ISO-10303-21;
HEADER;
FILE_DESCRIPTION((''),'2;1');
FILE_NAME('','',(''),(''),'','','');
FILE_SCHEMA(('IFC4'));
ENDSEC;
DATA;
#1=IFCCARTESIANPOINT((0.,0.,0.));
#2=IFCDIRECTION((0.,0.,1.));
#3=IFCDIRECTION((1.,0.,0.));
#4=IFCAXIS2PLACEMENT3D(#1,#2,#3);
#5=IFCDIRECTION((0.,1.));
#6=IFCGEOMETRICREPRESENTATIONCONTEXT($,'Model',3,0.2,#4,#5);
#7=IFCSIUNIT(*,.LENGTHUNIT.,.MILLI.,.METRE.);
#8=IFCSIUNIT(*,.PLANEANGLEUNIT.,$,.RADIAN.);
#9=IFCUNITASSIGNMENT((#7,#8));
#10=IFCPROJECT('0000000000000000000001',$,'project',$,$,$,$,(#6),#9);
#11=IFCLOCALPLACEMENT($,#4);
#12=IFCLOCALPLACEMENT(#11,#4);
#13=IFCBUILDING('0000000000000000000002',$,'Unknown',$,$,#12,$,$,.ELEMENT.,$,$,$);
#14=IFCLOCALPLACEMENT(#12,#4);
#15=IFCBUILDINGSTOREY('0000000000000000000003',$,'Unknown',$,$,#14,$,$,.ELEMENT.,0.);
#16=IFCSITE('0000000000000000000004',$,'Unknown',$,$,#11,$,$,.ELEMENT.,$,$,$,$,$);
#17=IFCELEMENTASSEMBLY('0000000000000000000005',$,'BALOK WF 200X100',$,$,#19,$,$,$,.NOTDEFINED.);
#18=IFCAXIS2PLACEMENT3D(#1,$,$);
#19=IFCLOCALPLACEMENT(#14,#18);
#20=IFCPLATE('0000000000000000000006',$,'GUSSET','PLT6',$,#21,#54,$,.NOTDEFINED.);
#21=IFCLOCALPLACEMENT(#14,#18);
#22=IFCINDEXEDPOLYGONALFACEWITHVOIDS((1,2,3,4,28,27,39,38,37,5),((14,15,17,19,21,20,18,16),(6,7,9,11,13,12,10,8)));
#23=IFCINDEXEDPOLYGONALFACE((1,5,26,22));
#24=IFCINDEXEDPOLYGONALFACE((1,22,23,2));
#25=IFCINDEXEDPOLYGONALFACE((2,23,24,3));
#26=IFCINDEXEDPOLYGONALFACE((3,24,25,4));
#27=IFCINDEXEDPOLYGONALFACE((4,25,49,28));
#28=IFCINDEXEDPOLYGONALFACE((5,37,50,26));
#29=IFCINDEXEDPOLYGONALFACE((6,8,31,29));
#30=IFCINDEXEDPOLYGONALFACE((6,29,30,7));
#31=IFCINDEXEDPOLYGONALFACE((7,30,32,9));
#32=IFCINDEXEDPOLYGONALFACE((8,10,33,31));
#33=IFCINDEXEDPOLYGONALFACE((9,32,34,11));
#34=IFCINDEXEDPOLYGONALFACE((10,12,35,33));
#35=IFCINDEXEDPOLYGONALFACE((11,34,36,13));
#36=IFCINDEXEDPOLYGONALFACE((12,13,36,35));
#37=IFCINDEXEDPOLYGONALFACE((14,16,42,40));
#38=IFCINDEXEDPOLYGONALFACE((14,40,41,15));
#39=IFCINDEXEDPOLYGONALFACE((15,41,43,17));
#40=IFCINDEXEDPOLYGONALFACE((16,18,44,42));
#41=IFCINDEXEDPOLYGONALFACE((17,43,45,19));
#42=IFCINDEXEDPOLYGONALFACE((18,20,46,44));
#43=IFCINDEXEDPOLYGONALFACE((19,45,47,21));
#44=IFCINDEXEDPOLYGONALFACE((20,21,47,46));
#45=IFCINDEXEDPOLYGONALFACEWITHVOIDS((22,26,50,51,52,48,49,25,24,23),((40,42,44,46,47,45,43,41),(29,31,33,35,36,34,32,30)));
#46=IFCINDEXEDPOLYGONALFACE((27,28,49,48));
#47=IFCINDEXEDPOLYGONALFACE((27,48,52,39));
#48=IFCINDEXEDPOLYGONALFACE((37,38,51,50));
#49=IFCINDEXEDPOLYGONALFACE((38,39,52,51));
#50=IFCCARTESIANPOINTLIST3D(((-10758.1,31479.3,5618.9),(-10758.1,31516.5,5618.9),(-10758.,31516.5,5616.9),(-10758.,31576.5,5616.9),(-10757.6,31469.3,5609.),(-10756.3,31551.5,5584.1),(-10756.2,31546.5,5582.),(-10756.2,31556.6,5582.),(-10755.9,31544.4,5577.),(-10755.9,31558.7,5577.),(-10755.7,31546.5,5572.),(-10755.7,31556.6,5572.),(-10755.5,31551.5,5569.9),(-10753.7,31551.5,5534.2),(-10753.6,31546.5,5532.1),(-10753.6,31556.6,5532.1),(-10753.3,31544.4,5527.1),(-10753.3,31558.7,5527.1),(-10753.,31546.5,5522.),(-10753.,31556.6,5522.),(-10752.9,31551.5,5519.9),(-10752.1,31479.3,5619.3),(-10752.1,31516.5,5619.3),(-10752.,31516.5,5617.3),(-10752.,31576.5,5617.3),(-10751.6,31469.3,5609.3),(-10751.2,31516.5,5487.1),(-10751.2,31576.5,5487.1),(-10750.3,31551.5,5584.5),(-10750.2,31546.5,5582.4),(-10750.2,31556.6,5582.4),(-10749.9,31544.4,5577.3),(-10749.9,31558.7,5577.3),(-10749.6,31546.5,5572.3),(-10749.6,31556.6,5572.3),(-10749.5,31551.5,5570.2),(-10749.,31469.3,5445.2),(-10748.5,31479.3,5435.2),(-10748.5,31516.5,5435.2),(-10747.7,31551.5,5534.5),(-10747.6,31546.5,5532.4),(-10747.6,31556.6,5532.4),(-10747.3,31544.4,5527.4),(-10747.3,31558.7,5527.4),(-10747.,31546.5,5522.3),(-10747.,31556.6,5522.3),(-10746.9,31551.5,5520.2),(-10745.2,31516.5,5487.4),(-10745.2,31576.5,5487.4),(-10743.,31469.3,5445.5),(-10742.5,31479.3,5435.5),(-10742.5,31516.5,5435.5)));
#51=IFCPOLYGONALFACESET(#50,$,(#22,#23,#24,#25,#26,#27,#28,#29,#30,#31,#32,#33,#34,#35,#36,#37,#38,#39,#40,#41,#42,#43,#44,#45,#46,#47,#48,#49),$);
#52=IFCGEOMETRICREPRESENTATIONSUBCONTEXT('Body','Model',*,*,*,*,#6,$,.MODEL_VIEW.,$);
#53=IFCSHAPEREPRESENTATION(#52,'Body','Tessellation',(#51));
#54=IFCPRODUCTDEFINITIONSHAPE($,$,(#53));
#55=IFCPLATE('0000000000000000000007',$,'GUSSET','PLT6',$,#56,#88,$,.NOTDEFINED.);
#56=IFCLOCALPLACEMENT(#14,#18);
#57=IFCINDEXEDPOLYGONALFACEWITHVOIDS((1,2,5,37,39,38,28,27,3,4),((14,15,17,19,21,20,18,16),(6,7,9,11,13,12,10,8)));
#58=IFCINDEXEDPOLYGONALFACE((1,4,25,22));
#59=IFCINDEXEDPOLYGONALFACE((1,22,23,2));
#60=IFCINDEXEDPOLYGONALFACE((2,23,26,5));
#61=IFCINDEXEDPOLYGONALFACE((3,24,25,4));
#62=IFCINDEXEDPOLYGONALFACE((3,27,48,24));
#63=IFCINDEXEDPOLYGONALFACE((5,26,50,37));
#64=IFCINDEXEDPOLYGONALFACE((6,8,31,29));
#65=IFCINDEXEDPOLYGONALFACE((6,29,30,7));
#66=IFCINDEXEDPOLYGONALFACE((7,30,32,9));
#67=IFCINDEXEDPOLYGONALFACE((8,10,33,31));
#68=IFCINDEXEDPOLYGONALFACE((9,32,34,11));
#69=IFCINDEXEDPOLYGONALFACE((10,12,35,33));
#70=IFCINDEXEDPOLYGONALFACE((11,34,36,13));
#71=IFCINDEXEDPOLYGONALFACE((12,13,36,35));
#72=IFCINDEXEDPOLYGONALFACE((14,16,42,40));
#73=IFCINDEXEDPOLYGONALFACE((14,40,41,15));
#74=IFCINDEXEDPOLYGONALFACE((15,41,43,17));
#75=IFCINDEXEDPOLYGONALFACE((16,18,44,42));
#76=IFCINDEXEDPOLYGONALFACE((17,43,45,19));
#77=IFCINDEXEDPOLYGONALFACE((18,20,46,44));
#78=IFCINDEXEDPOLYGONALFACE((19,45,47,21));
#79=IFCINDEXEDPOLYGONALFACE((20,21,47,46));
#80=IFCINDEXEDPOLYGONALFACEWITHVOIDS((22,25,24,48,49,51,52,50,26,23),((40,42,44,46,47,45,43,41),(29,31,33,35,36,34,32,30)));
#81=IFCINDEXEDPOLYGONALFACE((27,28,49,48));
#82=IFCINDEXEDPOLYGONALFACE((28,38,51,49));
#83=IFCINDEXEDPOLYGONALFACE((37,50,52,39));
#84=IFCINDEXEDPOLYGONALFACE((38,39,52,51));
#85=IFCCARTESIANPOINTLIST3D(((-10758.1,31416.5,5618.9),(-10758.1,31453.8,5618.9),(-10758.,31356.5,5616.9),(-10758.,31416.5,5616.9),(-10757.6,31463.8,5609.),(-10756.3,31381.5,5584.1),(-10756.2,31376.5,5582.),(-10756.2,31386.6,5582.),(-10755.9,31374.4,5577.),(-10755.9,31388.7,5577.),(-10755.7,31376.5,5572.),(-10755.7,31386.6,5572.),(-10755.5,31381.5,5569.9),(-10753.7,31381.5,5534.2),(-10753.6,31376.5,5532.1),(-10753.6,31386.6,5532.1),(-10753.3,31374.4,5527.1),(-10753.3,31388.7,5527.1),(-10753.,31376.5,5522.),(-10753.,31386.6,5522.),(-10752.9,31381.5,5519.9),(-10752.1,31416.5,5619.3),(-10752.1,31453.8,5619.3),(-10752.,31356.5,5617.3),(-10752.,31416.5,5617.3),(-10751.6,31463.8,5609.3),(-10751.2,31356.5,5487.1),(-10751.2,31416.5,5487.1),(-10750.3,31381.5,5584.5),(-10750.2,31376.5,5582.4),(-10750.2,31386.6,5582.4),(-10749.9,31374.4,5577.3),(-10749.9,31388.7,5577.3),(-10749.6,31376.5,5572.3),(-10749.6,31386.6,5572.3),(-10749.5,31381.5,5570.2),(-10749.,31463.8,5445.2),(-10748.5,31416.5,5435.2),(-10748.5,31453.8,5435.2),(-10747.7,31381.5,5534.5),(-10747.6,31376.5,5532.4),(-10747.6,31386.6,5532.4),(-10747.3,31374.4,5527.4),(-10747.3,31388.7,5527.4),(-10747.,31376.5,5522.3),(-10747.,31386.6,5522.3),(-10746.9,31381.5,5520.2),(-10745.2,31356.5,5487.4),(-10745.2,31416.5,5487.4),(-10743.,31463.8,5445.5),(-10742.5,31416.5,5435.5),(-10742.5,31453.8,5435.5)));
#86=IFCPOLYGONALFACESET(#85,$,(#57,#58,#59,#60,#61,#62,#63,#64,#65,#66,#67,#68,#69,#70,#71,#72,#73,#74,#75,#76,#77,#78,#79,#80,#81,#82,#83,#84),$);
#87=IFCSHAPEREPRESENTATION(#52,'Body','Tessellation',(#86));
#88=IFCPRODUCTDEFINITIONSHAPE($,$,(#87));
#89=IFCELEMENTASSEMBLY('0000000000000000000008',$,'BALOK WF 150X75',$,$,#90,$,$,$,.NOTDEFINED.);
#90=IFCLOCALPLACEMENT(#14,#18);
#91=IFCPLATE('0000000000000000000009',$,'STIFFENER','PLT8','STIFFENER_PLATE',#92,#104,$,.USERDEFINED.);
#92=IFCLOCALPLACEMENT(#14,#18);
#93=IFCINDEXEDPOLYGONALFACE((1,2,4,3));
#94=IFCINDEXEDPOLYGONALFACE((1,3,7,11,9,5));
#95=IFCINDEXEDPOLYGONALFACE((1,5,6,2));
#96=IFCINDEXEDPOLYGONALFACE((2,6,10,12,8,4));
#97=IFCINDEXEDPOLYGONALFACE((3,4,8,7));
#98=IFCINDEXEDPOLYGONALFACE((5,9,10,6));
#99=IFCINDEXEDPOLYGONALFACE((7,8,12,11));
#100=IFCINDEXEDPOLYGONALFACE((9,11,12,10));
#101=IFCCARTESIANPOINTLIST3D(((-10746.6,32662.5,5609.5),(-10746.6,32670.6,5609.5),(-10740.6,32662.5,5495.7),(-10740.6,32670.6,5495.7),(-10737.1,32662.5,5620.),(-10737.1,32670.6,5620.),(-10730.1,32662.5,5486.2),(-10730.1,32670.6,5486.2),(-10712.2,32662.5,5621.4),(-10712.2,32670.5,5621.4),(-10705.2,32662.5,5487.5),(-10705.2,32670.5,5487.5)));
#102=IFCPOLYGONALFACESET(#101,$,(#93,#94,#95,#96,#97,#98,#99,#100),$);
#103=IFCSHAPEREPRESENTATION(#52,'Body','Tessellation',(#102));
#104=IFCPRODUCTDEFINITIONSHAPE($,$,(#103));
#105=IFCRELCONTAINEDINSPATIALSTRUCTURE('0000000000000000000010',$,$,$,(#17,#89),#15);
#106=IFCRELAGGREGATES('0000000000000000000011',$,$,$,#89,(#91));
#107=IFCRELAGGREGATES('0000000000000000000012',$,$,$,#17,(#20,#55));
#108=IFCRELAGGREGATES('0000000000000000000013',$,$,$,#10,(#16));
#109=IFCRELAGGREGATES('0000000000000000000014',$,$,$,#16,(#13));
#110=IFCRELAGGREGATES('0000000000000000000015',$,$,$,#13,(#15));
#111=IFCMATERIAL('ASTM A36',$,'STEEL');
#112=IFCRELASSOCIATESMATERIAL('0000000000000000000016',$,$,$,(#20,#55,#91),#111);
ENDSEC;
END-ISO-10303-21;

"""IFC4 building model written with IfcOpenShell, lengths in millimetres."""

from ifc_helpers import new_model, si_unit, direction, frame, origin_with_axes, place, context, subcontext, project, spatial, line, indexed_curve, outline, extrude, material, element, aggregate, save


model = new_model("IFC4")

# Units and contexts
model_context = context("Model", 3, precision=0.2, world=origin_with_axes(), true_north=direction((0.0, 1.0)))
body_context = subcontext(model_context, "Body", "Model", "MODEL_VIEW")
ifc_project = project(units=[si_unit("LENGTHUNIT", "METRE", prefix="MILLI"), si_unit("PLANEANGLEUNIT", "RADIAN")], contexts=[model_context])

# Site, building, storey
site_placement = place(None, origin_with_axes())
site = spatial("IfcSite", under=ifc_project, at=site_placement, Name="Unknown", CompositionType="ELEMENT")
building_placement = place(site_placement, origin_with_axes())
building = spatial("IfcBuilding", under=site, at=building_placement, Name="Unknown", CompositionType="ELEMENT")
storey_placement = place(building_placement, origin_with_axes())
storey = spatial("IfcBuildingStorey", under=building, at=storey_placement, Name="Unknown", CompositionType="ELEMENT", Elevation=0.0)

# Element assemblies, plates, voiding features
assembly_1_placement = place(storey_placement, frame((-7044.1, 31466.5, 5721.5), z_axis=(0.0, 1.0, 0.0), x_axis=(-0.99863, 0.0, -0.052336)))
assembly_1 = element("IfcElementAssembly", 1, at=assembly_1_placement, inside=storey, Name="BALOK WF 200X100", PredefinedType="NOTDEFINED")
ifc_material_1 = material(Name="ASTM A36", Category="STEEL")
plate_1_placement = place(assembly_1_placement, frame((3711.2, 92.0, 2.8), z_axis=(1.0, 0.0, 0.0), x_axis=(0.0, 0.0, 1.0)))
plate_1 = element("IfcPlate", 2, at=plate_1_placement, material=ifc_material_1, Name="GUSSET", Description="PLT6", PredefinedType="NOTDEFINED", context=body_context, shape_type="SolidModel", body=[
    extrude(outline(indexed_curve([(0.0, 0.0), (47.2, 0.0), (47.2, 2.0), (107.3, 2.0), (107.3, 132.0), (47.2, 132.0), (47.2, 184.0), (0.0, 184.0)], segments=[line(1, 2, 3, 4, 5, 6, 7, 8, 1)])), frame((0.0, 0.0, 3.0), z_axis=(0.0, 0.0, 1.0), x_axis=(1.0, 0.0, 0.0)), (0.0, 0.0, -1.0), 6.0),
])
voiding_feature_1_placement = place(plate_1_placement, frame((10.0, 0.0, 0.0), z_axis=(0.0, 0.0, 1.0), x_axis=(-0.707107, 0.707107, 0.0)))
element("IfcVoidingFeature", 3, at=voiding_feature_1_placement, cuts=plate_1, Name="SLAB", PredefinedType="HOLE", context=body_context, shape_type="SolidModel", body=[
    extrude(outline(indexed_curve([(0.0, 0.0), (14.1, 0.0), (7.1, 7.1)], segments=[line(1, 2, 3, 1)])), frame((0.0, 0.0, 3.0), z_axis=(0.0, 0.0, 1.0), x_axis=(1.0, 0.0, 0.0)), (0.0, 0.0, -1.0), 6.0),
])
voiding_feature_2_placement = place(plate_1_placement, frame((0.0, 174.0, 0.0), z_axis=(0.0, 0.0, 1.0), x_axis=(0.707107, 0.707107, 0.0)))
element("IfcVoidingFeature", 4, at=voiding_feature_2_placement, cuts=plate_1, Name="SLAB", PredefinedType="HOLE", context=body_context, shape_type="SolidModel", body=[
    extrude(outline(indexed_curve([(0.0, 0.0), (14.1, 0.0), (7.1, 7.1)], segments=[line(1, 2, 3, 1)])), frame((0.0, 0.0, 3.0), z_axis=(0.0, 0.0, 1.0), x_axis=(1.0, 0.0, 0.0)), (0.0, 0.0, -1.0), 6.0),
])
voiding_feature_3_placement = place(plate_1_placement, frame((82.3, 92.0, -3.5), z_axis=(-1.0, 0.0, 0.0), x_axis=(0.0, 0.0, 1.0)))
element("IfcVoidingFeature", 5, at=voiding_feature_3_placement, cuts=plate_1, Name="BEAM", PredefinedType="HOLE", context=body_context, shape_type="SolidModel", body=[
    extrude(outline(indexed_curve([(7.1, 0.0), (5.1, 5.1), (0.0, 7.1), (-5.1, 5.1), (-7.1, 0.0), (-5.1, -5.1), (0.0, -7.1), (5.1, -5.1)], segments=[line(1, 2, 3, 4, 5, 6, 7, 8, 1)])), frame((0.0, 0.0, 0.0), z_axis=(-1.0, 0.0, 0.0), x_axis=(0.0, 0.0, 1.0)), (0.0, 0.0, -1.0), 7.0),
])
voiding_feature_4_placement = place(plate_1_placement, frame((82.3, 42.0, -3.5), z_axis=(-1.0, 0.0, 0.0), x_axis=(0.0, 0.0, 1.0)))
element("IfcVoidingFeature", 6, at=voiding_feature_4_placement, cuts=plate_1, Name="BEAM", PredefinedType="HOLE", context=body_context, shape_type="SolidModel", body=[
    extrude(outline(indexed_curve([(7.1, 0.0), (5.1, 5.1), (0.0, 7.1), (-5.1, 5.1), (-7.1, 0.0), (-5.1, -5.1), (0.0, -7.1), (5.1, -5.1)], segments=[line(1, 2, 3, 4, 5, 6, 7, 8, 1)])), frame((0.0, 0.0, 0.0), z_axis=(-1.0, 0.0, 0.0), x_axis=(0.0, 0.0, 1.0)), (0.0, 0.0, -1.0), 7.0),
])
plate_2_placement = place(assembly_1_placement, frame((3711.2, -92.0, -2.8), z_axis=(1.0, 0.0, 0.0), x_axis=(0.0, 0.0, -1.0)))
plate_2 = element("IfcPlate", 7, at=plate_2_placement, material=ifc_material_1, Name="GUSSET", Description="PLT6", PredefinedType="NOTDEFINED", context=body_context, shape_type="SolidModel", body=[
    extrude(outline(indexed_curve([(0.0, 0.0), (47.2, 0.0), (47.2, 52.0), (107.2, 52.0), (107.2, 182.0), (47.2, 182.0), (47.2, 184.0), (0.0, 184.0)], segments=[line(1, 2, 3, 4, 5, 6, 7, 8, 1)])), frame((0.0, 0.0, 3.0), z_axis=(0.0, 0.0, 1.0), x_axis=(1.0, 0.0, 0.0)), (0.0, 0.0, -1.0), 6.0),
])
voiding_feature_5_placement = place(plate_2_placement, frame((0.0, 174.0, 0.0), z_axis=(0.0, 0.0, 1.0), x_axis=(0.707107, 0.707107, 0.0)))
element("IfcVoidingFeature", 8, at=voiding_feature_5_placement, cuts=plate_2, Name="SLAB", PredefinedType="HOLE", context=body_context, shape_type="SolidModel", body=[
    extrude(outline(indexed_curve([(0.0, 0.0), (14.1, 0.0), (7.1, 7.1)], segments=[line(1, 2, 3, 1)])), frame((0.0, 0.0, 3.0), z_axis=(0.0, 0.0, 1.0), x_axis=(1.0, 0.0, 0.0)), (0.0, 0.0, -1.0), 6.0),
])
voiding_feature_6_placement = place(plate_2_placement, frame((10.0, 0.0, 0.0), z_axis=(0.0, 0.0, 1.0), x_axis=(-0.707107, 0.707107, 0.0)))
element("IfcVoidingFeature", 9, at=voiding_feature_6_placement, cuts=plate_2, Name="SLAB", PredefinedType="HOLE", context=body_context, shape_type="SolidModel", body=[
    extrude(outline(indexed_curve([(0.0, 0.0), (14.1, 0.0), (7.1, 7.1)], segments=[line(1, 2, 3, 1)])), frame((0.0, 0.0, 3.0), z_axis=(0.0, 0.0, 1.0), x_axis=(1.0, 0.0, 0.0)), (0.0, 0.0, -1.0), 6.0),
])
voiding_feature_7_placement = place(plate_2_placement, frame((82.2, 92.0, 3.5), z_axis=(1.0, 0.0, 0.0), x_axis=(0.0, 0.0, -1.0)))
element("IfcVoidingFeature", 10, at=voiding_feature_7_placement, cuts=plate_2, Name="BEAM", PredefinedType="HOLE", context=body_context, shape_type="SolidModel", body=[
    extrude(outline(indexed_curve([(7.1, 0.0), (5.1, 5.1), (0.0, 7.1), (-5.1, 5.1), (-7.1, 0.0), (-5.1, -5.1), (0.0, -7.1), (5.1, -5.1)], segments=[line(1, 2, 3, 4, 5, 6, 7, 8, 1)])), frame((0.0, 0.0, 0.0), z_axis=(-1.0, 0.0, 0.0), x_axis=(0.0, 0.0, 1.0)), (0.0, 0.0, -1.0), 7.0),
])
voiding_feature_8_placement = place(plate_2_placement, frame((82.2, 142.0, 3.5), z_axis=(1.0, 0.0, 0.0), x_axis=(0.0, 0.0, -1.0)))
element("IfcVoidingFeature", 11, at=voiding_feature_8_placement, cuts=plate_2, Name="BEAM", PredefinedType="HOLE", context=body_context, shape_type="SolidModel", body=[
    extrude(outline(indexed_curve([(7.1, 0.0), (5.1, 5.1), (0.0, 7.1), (-5.1, 5.1), (-7.1, 0.0), (-5.1, -5.1), (0.0, -7.1), (5.1, -5.1)], segments=[line(1, 2, 3, 4, 5, 6, 7, 8, 1)])), frame((0.0, 0.0, 0.0), z_axis=(-1.0, 0.0, 0.0), x_axis=(0.0, 0.0, 1.0)), (0.0, 0.0, -1.0), 7.0),
])
assembly_2_placement = place(storey_placement, frame((-10746.1, 33965.4, 5552.5), z_axis=(-0.99863, 0.0, -0.052336), x_axis=(0.0, -1.0, 0.0)))
assembly_2 = element("IfcElementAssembly", 12, at=assembly_2_placement, inside=storey, Name="BALOK WF 150X75", PredefinedType="NOTDEFINED")
plate_3_placement = place(assembly_2_placement, frame((1298.9, 67.0, -37.5), z_axis=(1.0, 0.0, 0.0), x_axis=(0.0, 0.0, 1.0)))
plate_3 = element("IfcPlate", 13, at=plate_3_placement, material=ifc_material_1, Name="STIFFENER", Description="PLT8", ObjectType="STIFFENER_PLATE", PredefinedType="USERDEFINED", context=body_context, shape_type="SolidModel", body=[
    extrude(outline(indexed_curve([(0.0, 0.0), (35.0, 0.0), (35.0, 134.0), (0.0, 134.0)], segments=[line(1, 2, 3, 4, 1)])), frame((0.0, 0.0, 4.0), z_axis=(0.0, 0.0, 1.0), x_axis=(1.0, 0.0, 0.0)), (0.0, 0.0, -1.0), 8.0),
])
voiding_feature_9_placement = place(plate_3_placement, frame((25.0, 134.0, 0.0), z_axis=(0.0, 0.0, 1.0), x_axis=(0.707107, -0.707107, 0.0)))
element("IfcVoidingFeature", 14, at=voiding_feature_9_placement, cuts=plate_3, Name="SLAB", PredefinedType="HOLE", context=body_context, shape_type="SolidModel", body=[
    extrude(outline(indexed_curve([(0.0, 0.0), (14.1, 0.0), (7.1, 7.1)], segments=[line(1, 2, 3, 1)])), frame((0.0, 0.0, 4.0), z_axis=(0.0, 0.0, 1.0), x_axis=(1.0, 0.0, 0.0)), (0.0, 0.0, -1.0), 8.0),
])
voiding_feature_10_placement = place(plate_3_placement, frame((25.0, 0.0, 0.0), z_axis=(0.0, 0.0, 1.0), x_axis=(1.0, 0.0, 0.0)))
element("IfcVoidingFeature", 15, at=voiding_feature_10_placement, cuts=plate_3, Name="SLAB", PredefinedType="HOLE", context=body_context, shape_type="SolidModel", body=[
    extrude(outline(indexed_curve([(0.0, 0.0), (10.0, 0.0), (10.0, 10.0)], segments=[line(1, 2, 3, 1)])), frame((0.0, 0.0, 4.0), z_axis=(0.0, 0.0, 1.0), x_axis=(1.0, 0.0, 0.0)), (0.0, 0.0, -1.0), 8.0),
])
aggregate(assembly_2, [plate_3])

aggregate(assembly_1, [plate_1, plate_2])

save(model, "model.ifc")
